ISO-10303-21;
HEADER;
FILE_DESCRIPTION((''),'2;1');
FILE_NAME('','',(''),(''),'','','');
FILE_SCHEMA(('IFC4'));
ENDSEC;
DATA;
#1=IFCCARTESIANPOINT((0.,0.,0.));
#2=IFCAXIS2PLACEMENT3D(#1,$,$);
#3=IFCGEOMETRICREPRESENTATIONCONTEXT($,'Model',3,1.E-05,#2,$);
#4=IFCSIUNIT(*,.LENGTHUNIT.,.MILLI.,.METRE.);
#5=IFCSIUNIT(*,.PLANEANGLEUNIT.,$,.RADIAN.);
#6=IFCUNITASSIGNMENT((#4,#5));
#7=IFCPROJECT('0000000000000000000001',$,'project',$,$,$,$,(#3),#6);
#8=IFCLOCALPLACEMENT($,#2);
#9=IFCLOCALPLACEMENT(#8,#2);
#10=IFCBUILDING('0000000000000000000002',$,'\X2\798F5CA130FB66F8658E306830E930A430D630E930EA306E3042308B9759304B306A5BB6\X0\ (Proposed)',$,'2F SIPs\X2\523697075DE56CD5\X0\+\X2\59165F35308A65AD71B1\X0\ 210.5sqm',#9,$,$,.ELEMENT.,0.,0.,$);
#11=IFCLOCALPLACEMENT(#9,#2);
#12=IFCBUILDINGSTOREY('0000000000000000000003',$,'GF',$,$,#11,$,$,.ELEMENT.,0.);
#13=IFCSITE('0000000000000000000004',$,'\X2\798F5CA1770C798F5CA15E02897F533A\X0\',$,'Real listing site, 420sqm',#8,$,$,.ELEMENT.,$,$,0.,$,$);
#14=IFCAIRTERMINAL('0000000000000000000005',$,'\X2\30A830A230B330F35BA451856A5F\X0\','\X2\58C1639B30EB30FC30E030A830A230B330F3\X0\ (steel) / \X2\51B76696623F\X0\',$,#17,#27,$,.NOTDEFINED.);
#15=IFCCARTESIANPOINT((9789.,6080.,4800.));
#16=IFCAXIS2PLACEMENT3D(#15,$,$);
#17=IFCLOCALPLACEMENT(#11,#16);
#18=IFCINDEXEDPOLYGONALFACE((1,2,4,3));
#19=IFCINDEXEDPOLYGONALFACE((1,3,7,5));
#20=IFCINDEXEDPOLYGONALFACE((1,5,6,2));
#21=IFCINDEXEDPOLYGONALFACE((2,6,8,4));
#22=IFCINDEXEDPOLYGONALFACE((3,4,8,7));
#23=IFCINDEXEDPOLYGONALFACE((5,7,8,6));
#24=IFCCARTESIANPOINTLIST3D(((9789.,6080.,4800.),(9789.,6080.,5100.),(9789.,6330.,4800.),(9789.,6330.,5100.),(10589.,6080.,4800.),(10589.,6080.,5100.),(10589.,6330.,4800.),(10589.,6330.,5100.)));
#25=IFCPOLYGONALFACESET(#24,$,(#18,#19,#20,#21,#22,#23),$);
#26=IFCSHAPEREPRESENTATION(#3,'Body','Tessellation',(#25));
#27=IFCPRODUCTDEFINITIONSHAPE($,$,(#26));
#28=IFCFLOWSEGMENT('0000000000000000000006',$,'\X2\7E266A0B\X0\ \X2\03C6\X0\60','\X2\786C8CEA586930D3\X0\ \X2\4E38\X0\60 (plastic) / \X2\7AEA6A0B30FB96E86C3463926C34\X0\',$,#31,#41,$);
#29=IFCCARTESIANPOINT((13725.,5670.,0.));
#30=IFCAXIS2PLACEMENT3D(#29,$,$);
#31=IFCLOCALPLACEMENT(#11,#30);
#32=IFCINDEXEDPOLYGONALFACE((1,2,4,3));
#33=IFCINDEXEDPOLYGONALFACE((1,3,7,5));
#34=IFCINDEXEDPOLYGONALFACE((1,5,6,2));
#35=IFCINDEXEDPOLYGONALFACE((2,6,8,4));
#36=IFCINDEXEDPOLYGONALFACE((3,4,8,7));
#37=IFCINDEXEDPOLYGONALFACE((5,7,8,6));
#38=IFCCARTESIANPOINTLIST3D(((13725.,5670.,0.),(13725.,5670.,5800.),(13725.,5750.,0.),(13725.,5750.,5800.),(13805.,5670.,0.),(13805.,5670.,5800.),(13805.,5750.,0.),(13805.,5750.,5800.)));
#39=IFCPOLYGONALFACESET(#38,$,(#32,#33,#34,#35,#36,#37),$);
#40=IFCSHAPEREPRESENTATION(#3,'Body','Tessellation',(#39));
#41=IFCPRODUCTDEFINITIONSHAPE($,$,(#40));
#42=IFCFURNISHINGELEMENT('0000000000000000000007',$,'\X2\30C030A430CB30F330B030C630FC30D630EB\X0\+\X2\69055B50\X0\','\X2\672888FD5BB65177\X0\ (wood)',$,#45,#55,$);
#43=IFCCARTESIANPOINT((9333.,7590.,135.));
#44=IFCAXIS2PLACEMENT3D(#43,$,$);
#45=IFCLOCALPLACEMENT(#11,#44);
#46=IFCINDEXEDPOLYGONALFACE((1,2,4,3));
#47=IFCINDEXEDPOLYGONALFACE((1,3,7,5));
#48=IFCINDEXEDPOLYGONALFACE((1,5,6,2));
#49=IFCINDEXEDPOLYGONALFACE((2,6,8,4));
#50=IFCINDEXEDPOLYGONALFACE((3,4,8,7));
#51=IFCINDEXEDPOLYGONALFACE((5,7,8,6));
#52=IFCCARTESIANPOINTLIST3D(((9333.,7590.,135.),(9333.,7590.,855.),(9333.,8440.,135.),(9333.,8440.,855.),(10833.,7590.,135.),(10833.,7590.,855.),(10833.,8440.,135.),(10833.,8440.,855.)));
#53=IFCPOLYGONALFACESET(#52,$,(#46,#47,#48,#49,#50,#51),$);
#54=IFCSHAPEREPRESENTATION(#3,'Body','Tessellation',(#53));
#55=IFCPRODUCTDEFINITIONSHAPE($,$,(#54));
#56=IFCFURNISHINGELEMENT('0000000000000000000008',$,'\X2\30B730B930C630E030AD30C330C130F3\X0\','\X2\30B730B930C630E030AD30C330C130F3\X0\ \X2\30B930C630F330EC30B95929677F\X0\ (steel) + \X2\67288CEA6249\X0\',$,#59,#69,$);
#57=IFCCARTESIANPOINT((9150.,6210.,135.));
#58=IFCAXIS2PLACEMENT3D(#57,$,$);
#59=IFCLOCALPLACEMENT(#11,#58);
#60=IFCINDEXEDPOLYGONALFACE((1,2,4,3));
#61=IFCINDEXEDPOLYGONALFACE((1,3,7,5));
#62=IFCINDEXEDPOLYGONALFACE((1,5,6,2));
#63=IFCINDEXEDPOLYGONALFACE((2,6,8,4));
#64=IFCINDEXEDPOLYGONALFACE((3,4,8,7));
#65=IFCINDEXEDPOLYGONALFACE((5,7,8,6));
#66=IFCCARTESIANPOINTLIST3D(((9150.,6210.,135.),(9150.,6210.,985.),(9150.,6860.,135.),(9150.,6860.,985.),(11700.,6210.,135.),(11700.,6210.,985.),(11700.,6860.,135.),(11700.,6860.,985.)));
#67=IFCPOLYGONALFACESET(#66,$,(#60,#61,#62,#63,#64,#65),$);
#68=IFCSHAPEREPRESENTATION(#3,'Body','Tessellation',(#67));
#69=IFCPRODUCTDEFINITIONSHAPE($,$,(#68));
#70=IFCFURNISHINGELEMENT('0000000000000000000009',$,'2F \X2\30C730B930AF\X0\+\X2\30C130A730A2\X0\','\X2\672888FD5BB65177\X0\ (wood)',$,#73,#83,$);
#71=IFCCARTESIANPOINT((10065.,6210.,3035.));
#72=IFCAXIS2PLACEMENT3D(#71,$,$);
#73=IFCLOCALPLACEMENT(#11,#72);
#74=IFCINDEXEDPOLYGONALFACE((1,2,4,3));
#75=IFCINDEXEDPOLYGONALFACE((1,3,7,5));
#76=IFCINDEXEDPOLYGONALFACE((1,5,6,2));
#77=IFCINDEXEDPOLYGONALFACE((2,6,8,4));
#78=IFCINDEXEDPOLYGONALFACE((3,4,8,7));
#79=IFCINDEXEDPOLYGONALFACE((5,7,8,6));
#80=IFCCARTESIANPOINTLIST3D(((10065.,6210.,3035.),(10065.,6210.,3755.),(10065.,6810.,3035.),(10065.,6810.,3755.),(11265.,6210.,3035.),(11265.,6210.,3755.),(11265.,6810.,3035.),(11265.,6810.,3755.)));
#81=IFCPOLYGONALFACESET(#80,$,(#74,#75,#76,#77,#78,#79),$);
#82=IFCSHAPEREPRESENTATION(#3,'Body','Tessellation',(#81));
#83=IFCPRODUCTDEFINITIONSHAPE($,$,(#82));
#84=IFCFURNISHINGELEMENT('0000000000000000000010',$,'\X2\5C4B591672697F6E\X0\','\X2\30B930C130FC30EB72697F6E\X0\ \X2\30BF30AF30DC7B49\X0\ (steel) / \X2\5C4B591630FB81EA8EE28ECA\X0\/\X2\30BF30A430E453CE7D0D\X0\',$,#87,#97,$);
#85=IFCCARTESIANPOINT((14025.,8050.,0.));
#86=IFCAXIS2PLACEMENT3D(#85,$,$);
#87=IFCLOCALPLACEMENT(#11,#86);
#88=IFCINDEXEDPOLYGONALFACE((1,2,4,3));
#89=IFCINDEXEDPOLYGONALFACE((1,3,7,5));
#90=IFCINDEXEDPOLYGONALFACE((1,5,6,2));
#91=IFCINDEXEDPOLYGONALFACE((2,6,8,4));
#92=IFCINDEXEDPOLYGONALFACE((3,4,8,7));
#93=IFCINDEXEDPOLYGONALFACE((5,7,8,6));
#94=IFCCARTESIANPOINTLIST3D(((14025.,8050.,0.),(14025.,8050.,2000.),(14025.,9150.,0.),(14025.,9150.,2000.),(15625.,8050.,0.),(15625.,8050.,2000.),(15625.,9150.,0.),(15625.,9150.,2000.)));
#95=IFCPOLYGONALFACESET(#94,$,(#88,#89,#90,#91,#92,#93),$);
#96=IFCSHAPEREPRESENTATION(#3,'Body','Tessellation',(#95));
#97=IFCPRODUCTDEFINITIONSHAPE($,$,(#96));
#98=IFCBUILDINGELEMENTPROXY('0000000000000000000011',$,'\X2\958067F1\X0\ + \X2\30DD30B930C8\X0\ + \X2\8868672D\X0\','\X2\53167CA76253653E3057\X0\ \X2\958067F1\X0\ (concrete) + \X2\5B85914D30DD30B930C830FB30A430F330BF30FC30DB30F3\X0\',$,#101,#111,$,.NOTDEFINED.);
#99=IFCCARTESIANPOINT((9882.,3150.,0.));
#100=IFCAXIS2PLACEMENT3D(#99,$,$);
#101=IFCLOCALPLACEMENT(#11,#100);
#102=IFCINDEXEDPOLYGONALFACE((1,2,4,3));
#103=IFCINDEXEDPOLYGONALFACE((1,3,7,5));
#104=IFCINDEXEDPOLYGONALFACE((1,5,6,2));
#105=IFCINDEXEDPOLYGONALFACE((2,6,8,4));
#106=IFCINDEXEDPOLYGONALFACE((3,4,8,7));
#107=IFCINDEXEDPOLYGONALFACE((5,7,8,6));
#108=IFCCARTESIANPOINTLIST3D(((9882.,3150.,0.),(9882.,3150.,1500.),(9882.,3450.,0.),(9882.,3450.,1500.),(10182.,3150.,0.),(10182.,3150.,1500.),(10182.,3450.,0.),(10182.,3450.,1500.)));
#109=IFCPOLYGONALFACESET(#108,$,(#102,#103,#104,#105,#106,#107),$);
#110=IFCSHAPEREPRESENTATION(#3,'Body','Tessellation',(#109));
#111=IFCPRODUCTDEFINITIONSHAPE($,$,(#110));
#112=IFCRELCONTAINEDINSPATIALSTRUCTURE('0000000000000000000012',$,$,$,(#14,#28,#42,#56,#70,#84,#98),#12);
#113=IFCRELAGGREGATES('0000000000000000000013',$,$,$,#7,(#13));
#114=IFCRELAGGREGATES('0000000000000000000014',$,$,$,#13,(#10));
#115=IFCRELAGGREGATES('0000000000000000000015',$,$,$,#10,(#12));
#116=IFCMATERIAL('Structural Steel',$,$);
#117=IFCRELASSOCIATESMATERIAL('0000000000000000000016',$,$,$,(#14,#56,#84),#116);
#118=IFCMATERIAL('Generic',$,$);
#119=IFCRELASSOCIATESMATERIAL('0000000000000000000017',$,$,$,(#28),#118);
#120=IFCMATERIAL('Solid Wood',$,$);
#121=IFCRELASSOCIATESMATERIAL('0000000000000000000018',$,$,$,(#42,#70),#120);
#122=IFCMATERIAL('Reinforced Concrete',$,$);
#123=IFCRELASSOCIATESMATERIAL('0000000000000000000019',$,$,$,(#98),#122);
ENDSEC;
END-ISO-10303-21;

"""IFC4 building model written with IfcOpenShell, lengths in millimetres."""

from ifc_helpers import new_model, si_unit, frame, frame_2d, origin, place, context, project, spatial, rectangle, extrude, material, element, save


model = new_model("IFC4")

# Units and contexts
model_context = context("Model", 3, precision=1e-05, world=origin())
ifc_project = project(units=[si_unit("LENGTHUNIT", "METRE", prefix="MILLI"), si_unit("PLANEANGLEUNIT", "RADIAN")], contexts=[model_context])

# Site, building, storey
site_placement = place(None, origin())
site = spatial("IfcSite", under=ifc_project, at=site_placement, Name="福岡県福岡市西区", ObjectType="Real listing site, 420sqm", CompositionType="ELEMENT", RefElevation=0.0)
building_placement = place(site_placement, origin())
building = spatial("IfcBuilding", under=site, at=building_placement, Name="福岡・書斎とライブラリのある静かな家 (Proposed)", ObjectType="2F SIPs制震工法+外張り断熱 210.5sqm", CompositionType="ELEMENT", ElevationOfRefHeight=0.0, ElevationOfTerrain=0.0)
storey_placement = place(building_placement, origin())
storey = spatial("IfcBuildingStorey", under=building, at=storey_placement, Name="GF", CompositionType="ELEMENT", Elevation=0.0)

# Shared definitions
ifc_material_1 = material(Name="Solid Wood")
ifc_material_2 = material(Name="Structural Steel")

# Shared definitions
ifc_material_3 = material(Name="Reinforced Concrete")

# Shared definitions
ifc_material_4 = material(Name="Generic")

# Air terminal
air_terminal_placement = place(storey_placement, frame((9789.0, 6080.0, 4800.0)))
element("IfcAirTerminal", 1, at=air_terminal_placement, inside=storey, material=ifc_material_2, Name="エアコン室内機", Description="壁掛ルームエアコン (steel) / 冷暖房", PredefinedType="NOTDEFINED", context=model_context, shape_type="SweptSolid", body=[
    extrude(rectangle(XDim=800.0, YDim=250.0, at=frame_2d((400.0, 125.0))), frame((9789.0, 6080.0, 4800.0)), (0.0, 0.0, 1.0), 300.0),
])

# Flow segment
flow_segment_placement = place(storey_placement, frame((13725.0, 5670.0, 0.0)))
element("IfcFlowSegment", 2, at=flow_segment_placement, inside=storey, material=ifc_material_4, Name="縦樋 φ60", Description="硬質塩ビ 丸60 (plastic) / 竪樋・雨水排水", context=model_context, shape_type="SweptSolid", body=[
    extrude(rectangle(XDim=80.0, YDim=80.0, at=frame_2d((40.0, 40.0))), frame((13725.0, 5670.0, 0.0)), (0.0, 0.0, 1.0), 5800.0),
])

# Furnishing elements
furnishing_1_placement = place(storey_placement, frame((9333.0, 7590.0, 135.0)))
element("IfcFurnishingElement", 3, at=furnishing_1_placement, inside=storey, material=ifc_material_1, Name="ダイニングテーブル+椅子", Description="木製家具 (wood)", context=model_context, shape_type="SweptSolid", body=[
    extrude(rectangle(XDim=1500.0, YDim=850.0, at=frame_2d((750.0, 425.0))), frame((9333.0, 7590.0, 135.0)), (0.0, 0.0, 1.0), 720.0),
])
furnishing_2_placement = place(storey_placement, frame((9150.0, 6210.0, 135.0)))
element("IfcFurnishingElement", 4, at=furnishing_2_placement, inside=storey, material=ifc_material_2, Name="システムキッチン", Description="システムキッチン ステンレス天板 (steel) + 木質扉", context=model_context, shape_type="SweptSolid", body=[
    extrude(rectangle(XDim=2550.0, YDim=650.0, at=frame_2d((1275.0, 325.0))), frame((9150.0, 6210.0, 135.0)), (0.0, 0.0, 1.0), 850.0),
])
furnishing_3_placement = place(storey_placement, frame((10065.0, 6210.0, 3035.0)))
element("IfcFurnishingElement", 5, at=furnishing_3_placement, inside=storey, material=ifc_material_1, Name="2F デスク+チェア", Description="木製家具 (wood)", context=model_context, shape_type="SweptSolid", body=[
    extrude(rectangle(XDim=1200.0, YDim=600.0, at=frame_2d((600.0, 300.0))), frame((10065.0, 6210.0, 3035.0)), (0.0, 0.0, 1.0), 720.0),
])
furnishing_4_placement = place(storey_placement, frame((14025.0, 8050.0, 0.0)))
element("IfcFurnishingElement", 6, at=furnishing_4_placement, inside=storey, material=ifc_material_2, Name="屋外物置", Description="スチール物置 タクボ等 (steel) / 屋外・自転車/タイヤ収納", context=model_context, shape_type="SweptSolid", body=[
    extrude(rectangle(XDim=1600.0, YDim=1100.0, at=frame_2d((800.0, 550.0))), frame((14025.0, 8050.0, 0.0)), (0.0, 0.0, 1.0), 2000.0),
])

# Building element proxy
proxy_placement = place(storey_placement, frame((9882.0, 3150.0, 0.0)))
element("IfcBuildingElementProxy", 7, at=proxy_placement, inside=storey, material=ifc_material_3, Name="門柱 + ポスト + 表札", Description="化粧打放し 門柱 (concrete) + 宅配ポスト・インターホン", PredefinedType="NOTDEFINED", context=model_context, shape_type="SweptSolid", body=[
    extrude(rectangle(XDim=300.0, YDim=300.0, at=frame_2d((150.0, 150.0))), frame((9882.0, 3150.0, 0.0)), (0.0, 0.0, 1.0), 1500.0),
])

save(model, "model.ifc")
